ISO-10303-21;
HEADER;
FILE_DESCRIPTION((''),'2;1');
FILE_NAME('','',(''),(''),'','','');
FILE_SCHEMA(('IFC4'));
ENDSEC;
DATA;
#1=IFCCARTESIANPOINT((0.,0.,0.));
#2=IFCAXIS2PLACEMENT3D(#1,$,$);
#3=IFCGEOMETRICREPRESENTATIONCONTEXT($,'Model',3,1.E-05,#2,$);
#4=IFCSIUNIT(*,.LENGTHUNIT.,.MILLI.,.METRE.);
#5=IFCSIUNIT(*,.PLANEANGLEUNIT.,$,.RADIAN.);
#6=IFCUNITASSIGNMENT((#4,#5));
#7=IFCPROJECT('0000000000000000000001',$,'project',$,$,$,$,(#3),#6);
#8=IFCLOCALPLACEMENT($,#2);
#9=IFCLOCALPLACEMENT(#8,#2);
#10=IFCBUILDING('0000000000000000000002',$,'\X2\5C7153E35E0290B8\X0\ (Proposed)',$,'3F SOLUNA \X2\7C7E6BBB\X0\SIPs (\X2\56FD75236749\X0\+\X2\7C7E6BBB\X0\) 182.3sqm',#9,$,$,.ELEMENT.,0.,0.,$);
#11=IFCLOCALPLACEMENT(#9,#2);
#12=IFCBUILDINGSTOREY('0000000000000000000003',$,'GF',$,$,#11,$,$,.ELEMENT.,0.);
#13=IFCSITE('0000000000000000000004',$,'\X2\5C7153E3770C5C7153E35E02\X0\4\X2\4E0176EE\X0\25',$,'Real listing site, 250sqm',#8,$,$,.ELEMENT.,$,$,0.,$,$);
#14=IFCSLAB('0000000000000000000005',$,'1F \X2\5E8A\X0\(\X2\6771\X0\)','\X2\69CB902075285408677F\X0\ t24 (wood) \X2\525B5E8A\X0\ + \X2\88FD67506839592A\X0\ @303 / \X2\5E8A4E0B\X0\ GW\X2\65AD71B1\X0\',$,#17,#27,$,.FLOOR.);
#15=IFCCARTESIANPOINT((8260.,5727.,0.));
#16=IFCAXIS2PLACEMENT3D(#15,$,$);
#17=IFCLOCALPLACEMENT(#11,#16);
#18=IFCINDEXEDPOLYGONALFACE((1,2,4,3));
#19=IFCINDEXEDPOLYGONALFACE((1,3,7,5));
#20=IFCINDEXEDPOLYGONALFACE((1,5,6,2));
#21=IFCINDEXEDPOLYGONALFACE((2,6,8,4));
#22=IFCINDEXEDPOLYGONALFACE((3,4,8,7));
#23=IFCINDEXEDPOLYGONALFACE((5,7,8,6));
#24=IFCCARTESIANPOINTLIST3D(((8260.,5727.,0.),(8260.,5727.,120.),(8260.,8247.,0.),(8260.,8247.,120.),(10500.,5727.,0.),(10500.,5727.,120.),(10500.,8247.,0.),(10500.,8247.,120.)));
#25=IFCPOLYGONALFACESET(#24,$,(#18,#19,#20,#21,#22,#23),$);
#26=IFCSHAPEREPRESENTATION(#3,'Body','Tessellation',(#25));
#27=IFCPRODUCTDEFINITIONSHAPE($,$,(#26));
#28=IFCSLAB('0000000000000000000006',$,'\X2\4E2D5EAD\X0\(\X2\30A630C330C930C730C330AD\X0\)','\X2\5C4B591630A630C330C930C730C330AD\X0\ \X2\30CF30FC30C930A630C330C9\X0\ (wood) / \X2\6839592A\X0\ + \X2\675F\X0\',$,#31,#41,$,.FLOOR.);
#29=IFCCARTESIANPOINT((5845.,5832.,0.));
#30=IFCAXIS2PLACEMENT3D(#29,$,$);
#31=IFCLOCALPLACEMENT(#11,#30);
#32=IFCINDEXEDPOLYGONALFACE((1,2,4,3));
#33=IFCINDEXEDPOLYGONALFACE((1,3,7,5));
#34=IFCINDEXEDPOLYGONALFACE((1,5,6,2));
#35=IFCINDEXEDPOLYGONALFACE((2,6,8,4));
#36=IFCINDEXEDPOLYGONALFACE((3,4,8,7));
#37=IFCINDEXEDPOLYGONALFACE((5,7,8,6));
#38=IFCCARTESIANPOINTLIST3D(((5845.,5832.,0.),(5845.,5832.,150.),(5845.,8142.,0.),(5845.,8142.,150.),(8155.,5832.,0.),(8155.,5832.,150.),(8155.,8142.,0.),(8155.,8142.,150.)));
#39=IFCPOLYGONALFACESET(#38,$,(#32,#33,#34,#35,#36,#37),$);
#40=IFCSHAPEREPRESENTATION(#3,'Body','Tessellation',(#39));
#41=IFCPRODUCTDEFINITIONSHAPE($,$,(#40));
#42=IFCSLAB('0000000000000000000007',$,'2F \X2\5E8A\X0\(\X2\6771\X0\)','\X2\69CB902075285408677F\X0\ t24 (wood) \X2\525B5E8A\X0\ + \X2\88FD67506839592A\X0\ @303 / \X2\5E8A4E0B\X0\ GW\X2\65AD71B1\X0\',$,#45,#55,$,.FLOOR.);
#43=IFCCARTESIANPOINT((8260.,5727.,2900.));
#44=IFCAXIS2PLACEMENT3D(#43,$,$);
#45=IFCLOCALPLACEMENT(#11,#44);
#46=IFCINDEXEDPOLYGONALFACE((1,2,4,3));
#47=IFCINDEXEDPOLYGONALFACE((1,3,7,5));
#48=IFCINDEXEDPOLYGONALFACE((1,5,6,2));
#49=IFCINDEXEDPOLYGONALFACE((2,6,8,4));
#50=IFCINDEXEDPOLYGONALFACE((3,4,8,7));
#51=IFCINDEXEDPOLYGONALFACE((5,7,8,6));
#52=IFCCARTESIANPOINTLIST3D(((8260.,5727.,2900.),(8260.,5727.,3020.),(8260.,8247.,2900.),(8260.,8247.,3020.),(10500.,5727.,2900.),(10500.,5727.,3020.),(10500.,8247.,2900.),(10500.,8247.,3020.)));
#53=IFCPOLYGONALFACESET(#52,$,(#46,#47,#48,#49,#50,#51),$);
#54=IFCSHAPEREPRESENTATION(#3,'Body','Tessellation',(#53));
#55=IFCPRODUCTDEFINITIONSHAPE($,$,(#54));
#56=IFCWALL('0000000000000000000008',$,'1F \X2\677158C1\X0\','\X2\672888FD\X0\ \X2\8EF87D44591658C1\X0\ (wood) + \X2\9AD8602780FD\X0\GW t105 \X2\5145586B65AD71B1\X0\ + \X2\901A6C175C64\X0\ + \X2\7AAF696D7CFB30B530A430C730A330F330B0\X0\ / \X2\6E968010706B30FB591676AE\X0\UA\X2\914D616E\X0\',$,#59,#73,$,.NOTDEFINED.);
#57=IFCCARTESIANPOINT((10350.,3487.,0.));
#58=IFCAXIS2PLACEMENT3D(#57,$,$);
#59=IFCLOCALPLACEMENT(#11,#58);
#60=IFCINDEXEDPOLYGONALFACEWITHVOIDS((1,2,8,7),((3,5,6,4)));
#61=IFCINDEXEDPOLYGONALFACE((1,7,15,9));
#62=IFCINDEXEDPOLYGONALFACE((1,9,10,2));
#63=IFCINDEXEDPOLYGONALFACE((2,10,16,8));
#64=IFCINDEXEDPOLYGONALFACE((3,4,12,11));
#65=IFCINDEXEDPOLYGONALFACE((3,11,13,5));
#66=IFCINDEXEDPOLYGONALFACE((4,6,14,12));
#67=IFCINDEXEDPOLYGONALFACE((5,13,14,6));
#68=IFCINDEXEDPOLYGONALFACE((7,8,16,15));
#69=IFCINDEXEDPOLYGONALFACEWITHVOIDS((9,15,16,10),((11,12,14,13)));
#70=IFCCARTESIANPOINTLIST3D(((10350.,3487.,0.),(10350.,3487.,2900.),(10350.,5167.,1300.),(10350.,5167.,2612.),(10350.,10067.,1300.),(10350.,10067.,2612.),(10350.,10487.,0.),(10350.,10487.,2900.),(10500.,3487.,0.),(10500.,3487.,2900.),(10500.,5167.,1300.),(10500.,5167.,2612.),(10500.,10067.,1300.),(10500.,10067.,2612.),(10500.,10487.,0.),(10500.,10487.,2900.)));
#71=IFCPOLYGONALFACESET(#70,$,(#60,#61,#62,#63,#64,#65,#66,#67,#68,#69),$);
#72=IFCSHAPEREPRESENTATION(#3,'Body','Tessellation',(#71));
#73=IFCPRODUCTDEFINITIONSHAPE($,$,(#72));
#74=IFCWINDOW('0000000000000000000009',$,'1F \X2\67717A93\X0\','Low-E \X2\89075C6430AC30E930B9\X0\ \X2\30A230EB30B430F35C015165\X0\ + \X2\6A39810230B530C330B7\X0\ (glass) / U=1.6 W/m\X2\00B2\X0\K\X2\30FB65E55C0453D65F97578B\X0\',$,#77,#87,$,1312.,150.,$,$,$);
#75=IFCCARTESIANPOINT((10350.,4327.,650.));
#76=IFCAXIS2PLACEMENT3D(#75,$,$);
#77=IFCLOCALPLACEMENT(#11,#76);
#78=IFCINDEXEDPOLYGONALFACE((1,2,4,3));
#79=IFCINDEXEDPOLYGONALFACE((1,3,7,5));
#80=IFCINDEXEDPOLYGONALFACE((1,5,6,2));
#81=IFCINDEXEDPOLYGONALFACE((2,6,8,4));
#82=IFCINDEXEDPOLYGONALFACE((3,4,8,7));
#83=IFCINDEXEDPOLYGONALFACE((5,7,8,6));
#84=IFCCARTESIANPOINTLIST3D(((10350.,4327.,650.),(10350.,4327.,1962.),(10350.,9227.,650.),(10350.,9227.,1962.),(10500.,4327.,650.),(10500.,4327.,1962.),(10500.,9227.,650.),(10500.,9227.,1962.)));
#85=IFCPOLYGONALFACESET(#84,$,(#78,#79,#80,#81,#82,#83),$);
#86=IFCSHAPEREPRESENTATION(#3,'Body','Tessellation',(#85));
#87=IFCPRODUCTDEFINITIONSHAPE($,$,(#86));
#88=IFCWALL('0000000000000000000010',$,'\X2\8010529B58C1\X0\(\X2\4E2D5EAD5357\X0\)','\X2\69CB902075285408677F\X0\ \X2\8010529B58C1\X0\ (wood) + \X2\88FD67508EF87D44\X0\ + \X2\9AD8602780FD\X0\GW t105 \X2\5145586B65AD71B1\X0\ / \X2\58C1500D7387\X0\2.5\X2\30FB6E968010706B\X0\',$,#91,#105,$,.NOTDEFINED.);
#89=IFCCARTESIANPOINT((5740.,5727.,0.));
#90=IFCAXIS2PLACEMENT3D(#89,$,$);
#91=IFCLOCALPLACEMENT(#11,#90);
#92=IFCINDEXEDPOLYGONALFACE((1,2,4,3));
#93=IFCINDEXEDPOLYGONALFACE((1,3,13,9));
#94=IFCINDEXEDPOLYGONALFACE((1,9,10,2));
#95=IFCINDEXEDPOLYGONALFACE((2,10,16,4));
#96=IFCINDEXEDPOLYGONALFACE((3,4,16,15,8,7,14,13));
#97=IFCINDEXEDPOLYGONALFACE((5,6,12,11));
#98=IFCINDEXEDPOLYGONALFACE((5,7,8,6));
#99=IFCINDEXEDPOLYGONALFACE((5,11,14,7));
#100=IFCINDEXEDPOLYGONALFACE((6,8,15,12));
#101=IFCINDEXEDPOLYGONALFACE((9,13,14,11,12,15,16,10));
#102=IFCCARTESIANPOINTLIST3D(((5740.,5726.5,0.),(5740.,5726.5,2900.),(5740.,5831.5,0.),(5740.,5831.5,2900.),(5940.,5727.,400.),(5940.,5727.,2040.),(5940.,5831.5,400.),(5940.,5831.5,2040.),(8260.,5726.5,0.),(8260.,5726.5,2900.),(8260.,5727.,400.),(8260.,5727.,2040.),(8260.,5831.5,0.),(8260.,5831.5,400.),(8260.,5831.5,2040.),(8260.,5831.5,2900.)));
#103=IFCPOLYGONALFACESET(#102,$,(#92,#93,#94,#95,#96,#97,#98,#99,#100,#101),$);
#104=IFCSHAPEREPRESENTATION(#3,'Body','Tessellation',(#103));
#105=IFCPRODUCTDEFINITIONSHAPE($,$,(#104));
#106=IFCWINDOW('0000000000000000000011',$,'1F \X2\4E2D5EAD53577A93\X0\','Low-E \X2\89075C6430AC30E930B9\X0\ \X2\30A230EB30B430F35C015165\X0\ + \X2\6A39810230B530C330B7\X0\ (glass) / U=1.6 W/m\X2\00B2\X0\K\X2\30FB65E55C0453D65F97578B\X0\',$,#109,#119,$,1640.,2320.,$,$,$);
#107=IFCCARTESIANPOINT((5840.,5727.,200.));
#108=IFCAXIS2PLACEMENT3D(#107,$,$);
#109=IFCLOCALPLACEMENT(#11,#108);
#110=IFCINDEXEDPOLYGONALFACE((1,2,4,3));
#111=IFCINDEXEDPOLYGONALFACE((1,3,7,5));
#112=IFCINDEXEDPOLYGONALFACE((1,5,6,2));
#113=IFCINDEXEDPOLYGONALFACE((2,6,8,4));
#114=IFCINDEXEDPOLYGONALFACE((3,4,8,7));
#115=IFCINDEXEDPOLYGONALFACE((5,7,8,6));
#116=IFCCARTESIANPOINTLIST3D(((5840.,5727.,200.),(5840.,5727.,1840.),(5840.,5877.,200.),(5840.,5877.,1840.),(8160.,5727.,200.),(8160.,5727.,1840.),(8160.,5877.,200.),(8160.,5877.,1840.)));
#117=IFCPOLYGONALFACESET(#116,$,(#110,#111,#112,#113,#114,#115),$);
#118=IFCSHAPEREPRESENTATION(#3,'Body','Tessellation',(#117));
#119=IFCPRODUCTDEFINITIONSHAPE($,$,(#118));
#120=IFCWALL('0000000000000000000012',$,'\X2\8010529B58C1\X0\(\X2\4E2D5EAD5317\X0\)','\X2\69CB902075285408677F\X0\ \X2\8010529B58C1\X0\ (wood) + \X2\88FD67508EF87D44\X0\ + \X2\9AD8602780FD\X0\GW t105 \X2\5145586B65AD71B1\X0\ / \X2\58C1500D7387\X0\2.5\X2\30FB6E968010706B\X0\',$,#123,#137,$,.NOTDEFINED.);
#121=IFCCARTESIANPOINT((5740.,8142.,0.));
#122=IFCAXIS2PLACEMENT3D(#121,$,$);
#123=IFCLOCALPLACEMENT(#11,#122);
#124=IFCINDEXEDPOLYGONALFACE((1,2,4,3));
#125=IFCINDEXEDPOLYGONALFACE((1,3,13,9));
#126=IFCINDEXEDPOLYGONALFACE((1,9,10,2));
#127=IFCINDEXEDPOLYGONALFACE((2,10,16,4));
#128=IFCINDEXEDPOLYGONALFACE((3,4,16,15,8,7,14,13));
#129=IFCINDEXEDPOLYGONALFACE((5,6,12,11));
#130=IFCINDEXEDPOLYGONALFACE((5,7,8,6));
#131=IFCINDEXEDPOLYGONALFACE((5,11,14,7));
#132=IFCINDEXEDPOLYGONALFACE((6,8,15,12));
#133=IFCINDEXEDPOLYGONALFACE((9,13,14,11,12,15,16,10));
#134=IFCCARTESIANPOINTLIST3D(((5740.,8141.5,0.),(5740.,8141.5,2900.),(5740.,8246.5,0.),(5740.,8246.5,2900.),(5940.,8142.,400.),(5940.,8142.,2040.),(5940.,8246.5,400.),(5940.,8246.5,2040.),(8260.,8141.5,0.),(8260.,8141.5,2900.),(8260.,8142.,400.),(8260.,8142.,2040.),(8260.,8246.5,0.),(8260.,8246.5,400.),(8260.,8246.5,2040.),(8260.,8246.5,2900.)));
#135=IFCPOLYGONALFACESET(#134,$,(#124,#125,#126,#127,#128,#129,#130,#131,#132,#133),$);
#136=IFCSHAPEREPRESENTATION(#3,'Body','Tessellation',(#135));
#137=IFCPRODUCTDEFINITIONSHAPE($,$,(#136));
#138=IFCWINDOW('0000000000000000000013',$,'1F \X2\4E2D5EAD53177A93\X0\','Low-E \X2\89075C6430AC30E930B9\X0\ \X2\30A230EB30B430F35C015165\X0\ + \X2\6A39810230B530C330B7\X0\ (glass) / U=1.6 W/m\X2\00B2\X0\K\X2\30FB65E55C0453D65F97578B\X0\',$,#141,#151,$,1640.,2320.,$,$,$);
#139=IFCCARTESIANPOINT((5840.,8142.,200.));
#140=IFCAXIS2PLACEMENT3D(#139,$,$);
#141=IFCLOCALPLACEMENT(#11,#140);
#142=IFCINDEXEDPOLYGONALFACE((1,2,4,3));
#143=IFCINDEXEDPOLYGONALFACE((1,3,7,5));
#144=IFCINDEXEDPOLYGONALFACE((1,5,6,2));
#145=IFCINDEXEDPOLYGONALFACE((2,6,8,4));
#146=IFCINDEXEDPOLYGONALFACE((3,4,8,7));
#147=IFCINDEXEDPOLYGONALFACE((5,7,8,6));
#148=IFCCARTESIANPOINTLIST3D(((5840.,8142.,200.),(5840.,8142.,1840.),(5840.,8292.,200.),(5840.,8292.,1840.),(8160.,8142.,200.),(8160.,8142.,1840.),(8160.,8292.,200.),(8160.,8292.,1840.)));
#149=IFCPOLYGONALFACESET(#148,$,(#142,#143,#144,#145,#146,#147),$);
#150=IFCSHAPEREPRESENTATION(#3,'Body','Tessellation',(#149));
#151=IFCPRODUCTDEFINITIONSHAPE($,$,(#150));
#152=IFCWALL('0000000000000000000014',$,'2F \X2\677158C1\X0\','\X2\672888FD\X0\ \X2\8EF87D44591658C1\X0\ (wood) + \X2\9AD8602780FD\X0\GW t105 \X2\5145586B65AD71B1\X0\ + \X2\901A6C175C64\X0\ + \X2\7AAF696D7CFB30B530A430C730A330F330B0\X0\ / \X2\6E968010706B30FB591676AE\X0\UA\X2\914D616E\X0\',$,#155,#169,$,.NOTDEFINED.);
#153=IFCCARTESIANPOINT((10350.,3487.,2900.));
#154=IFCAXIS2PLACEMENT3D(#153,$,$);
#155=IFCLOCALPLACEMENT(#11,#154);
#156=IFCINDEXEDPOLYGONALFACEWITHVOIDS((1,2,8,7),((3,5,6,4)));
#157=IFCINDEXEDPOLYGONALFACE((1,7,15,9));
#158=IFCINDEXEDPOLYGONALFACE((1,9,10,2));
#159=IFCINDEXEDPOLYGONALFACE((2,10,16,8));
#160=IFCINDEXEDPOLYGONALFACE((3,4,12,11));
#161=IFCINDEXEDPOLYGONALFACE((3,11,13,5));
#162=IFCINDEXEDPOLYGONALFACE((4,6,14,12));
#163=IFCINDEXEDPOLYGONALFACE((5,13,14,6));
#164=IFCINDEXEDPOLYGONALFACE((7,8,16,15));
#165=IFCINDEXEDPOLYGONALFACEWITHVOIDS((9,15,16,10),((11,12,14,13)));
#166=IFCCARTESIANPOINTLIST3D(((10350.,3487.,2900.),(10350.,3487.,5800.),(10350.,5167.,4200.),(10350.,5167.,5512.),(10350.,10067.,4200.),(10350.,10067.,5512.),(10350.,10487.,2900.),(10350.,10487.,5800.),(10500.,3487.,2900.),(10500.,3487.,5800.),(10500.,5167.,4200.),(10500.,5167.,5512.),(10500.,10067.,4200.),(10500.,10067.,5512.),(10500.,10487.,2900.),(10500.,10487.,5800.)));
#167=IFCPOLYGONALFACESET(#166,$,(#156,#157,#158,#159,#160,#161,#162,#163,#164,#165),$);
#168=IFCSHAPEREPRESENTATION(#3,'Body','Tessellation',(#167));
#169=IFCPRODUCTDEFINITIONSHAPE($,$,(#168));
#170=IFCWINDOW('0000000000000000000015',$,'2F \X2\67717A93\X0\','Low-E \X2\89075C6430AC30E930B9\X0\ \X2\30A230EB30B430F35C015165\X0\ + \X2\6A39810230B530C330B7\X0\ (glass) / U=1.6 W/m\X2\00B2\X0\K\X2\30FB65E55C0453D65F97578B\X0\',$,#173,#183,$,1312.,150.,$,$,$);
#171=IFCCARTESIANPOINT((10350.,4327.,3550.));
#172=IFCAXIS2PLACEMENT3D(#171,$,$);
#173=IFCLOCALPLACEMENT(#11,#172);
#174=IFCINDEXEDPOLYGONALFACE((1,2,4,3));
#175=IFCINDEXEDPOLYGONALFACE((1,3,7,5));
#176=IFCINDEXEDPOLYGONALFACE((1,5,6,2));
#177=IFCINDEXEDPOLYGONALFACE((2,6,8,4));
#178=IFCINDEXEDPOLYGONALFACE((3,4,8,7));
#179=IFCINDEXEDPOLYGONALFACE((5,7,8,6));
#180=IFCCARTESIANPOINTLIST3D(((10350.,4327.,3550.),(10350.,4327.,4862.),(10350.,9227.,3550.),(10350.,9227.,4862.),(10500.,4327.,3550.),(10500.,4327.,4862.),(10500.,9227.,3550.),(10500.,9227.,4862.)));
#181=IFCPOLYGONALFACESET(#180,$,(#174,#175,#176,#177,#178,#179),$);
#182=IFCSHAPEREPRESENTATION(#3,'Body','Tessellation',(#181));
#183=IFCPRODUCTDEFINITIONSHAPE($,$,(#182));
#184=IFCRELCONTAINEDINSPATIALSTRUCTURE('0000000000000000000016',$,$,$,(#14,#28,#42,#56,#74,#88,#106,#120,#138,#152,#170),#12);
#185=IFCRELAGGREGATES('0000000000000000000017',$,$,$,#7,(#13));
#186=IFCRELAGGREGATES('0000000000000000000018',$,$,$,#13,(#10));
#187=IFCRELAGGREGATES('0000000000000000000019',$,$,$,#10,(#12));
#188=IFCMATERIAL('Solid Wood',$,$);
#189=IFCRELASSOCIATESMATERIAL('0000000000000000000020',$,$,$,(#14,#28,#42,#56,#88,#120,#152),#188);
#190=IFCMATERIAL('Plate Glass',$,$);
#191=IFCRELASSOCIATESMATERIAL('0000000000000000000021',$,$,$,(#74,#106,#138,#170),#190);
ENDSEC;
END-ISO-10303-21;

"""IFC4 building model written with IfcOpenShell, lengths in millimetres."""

from ifc_helpers import new_model, si_unit, frame, frame_2d, origin, place, context, project, spatial, rectangle, extrude, material, element, fill, save


model = new_model("IFC4")

# Units and contexts
model_context = context("Model", 3, precision=1e-05, world=origin())
ifc_project = project(units=[si_unit("LENGTHUNIT", "METRE", prefix="MILLI"), si_unit("PLANEANGLEUNIT", "RADIAN")], contexts=[model_context])

# Site, building, storey
site_placement = place(None, origin())
site = spatial("IfcSite", under=ifc_project, at=site_placement, Name="山口県山口市4丁目25", ObjectType="Real listing site, 250sqm", CompositionType="ELEMENT", RefElevation=0.0)
building_placement = place(site_placement, origin())
building = spatial("IfcBuilding", under=site, at=building_placement, Name="山口市邸 (Proposed)", ObjectType="3F SOLUNA 籾殻SIPs (国産杉+籾殻) 182.3sqm", CompositionType="ELEMENT", ElevationOfRefHeight=0.0, ElevationOfTerrain=0.0)
storey_placement = place(building_placement, origin())
storey = spatial("IfcBuildingStorey", under=building, at=storey_placement, Name="GF", CompositionType="ELEMENT", Elevation=0.0)

# Slabs
ifc_material_1 = material(Name="Solid Wood")
slab_1_placement = place(storey_placement, frame((8260.0, 5727.0, 0.0)))
element("IfcSlab", 1, at=slab_1_placement, inside=storey, material=ifc_material_1, Name="1F 床(東)", Description="構造用合板 t24 (wood) 剛床 + 製材根太 @303 / 床下 GW断熱", PredefinedType="FLOOR", context=model_context, shape_type="SweptSolid", body=[
    extrude(rectangle(XDim=2240.0, YDim=2520.0, at=frame_2d((1120.0, 1260.0))), frame((8260.0, 5727.0, 0.0)), (0.0, 0.0, 1.0), 120.0),
])
slab_2_placement = place(storey_placement, frame((5845.0, 5832.0, 0.0)))
element("IfcSlab", 2, at=slab_2_placement, inside=storey, material=ifc_material_1, Name="中庭(ウッドデッキ)", Description="屋外ウッドデッキ ハードウッド (wood) / 根太 + 束", PredefinedType="FLOOR", context=model_context, shape_type="SweptSolid", body=[
    extrude(rectangle(XDim=2310.0, YDim=2310.0, at=frame_2d((1155.0, 1155.0))), frame((5845.0, 5832.0, 0.0)), (0.0, 0.0, 1.0), 150.0),
])
slab_3_placement = place(storey_placement, frame((8260.0, 5727.0, 2900.0)))
element("IfcSlab", 3, at=slab_3_placement, inside=storey, material=ifc_material_1, Name="2F 床(東)", Description="構造用合板 t24 (wood) 剛床 + 製材根太 @303 / 床下 GW断熱", PredefinedType="FLOOR", context=model_context, shape_type="SweptSolid", body=[
    extrude(rectangle(XDim=2240.0, YDim=2520.0, at=frame_2d((1120.0, 1260.0))), frame((8260.0, 5727.0, 2900.0)), (0.0, 0.0, 1.0), 120.0),
])

# Walls, openings, windows
wall_1_placement = place(storey_placement, frame((10350.0, 3487.0, 0.0)))
wall_1 = element("IfcWall", 4, at=wall_1_placement, inside=storey, material=ifc_material_1, Name="1F 東壁", Description="木製 軸組外壁 (wood) + 高性能GW t105 充填断熱 + 通気層 + 窯業系サイディング / 準耐火・外皮UA配慮", PredefinedType="NOTDEFINED", context=model_context, shape_type="SweptSolid", body=[
    extrude(rectangle(XDim=150.0, YDim=7000.0, at=frame_2d((75.0, 3500.0))), frame((10350.0, 3487.0, 0.0)), (0.0, 0.0, 1.0), 2900.0),
])
opening_1_placement = place(storey_placement, frame((10350.0, 4327.0, 650.0)))
opening_1 = element("IfcOpeningElement", 5, at=opening_1_placement, cuts=wall_1, PredefinedType="NOTDEFINED", context=model_context, shape_type="SweptSolid", body=[
    extrude(rectangle(XDim=150.0, YDim=4900.0, at=frame_2d((75.0, 2450.0))), frame((10350.0, 4327.0, 650.0)), (0.0, 0.0, 1.0), 1312.0),
])
ifc_material_2 = material(Name="Plate Glass")
window_1_placement = place(storey_placement, frame((10350.0, 4327.0, 650.0)))
window_1 = element("IfcWindow", 6, at=window_1_placement, inside=storey, material=ifc_material_2, Name="1F 東窓", Description="Low-E 複層ガラス アルゴン封入 + 樹脂サッシ (glass) / U=1.6 W/m²K・日射取得型", OverallHeight=1312.0, OverallWidth=150.0, context=model_context, shape_type="SweptSolid", body=[
    extrude(rectangle(XDim=150.0, YDim=4900.0, at=frame_2d((75.0, 2450.0))), frame((10350.0, 4327.0, 650.0)), (0.0, 0.0, 1.0), 1312.0),
])
fill(opening_1, window_1)
wall_2_placement = place(storey_placement, frame((5740.0, 5727.0, 0.0)))
wall_2 = element("IfcWall", 7, at=wall_2_placement, inside=storey, material=ifc_material_1, Name="耐力壁(中庭南)", Description="構造用合板 耐力壁 (wood) + 製材軸組 + 高性能GW t105 充填断熱 / 壁倍率2.5・準耐火", PredefinedType="NOTDEFINED", context=model_context, shape_type="SweptSolid", body=[
    extrude(rectangle(XDim=2520.0, YDim=105.0, at=frame_2d((1260.0, 52.0))), frame((5740.0, 5727.0, 0.0)), (0.0, 0.0, 1.0), 2900.0),
])
opening_2_placement = place(storey_placement, frame((5840.0, 5727.0, 200.0)))
opening_2 = element("IfcOpeningElement", 8, at=opening_2_placement, cuts=wall_2, PredefinedType="NOTDEFINED", context=model_context, shape_type="SweptSolid", body=[
    extrude(rectangle(XDim=2320.0, YDim=150.0, at=frame_2d((1160.0, 75.0))), frame((5840.0, 5727.0, 200.0)), (0.0, 0.0, 1.0), 1640.0),
])
window_2_placement = place(storey_placement, frame((5840.0, 5727.0, 200.0)))
window_2 = element("IfcWindow", 9, at=window_2_placement, inside=storey, material=ifc_material_2, Name="1F 中庭南窓", Description="Low-E 複層ガラス アルゴン封入 + 樹脂サッシ (glass) / U=1.6 W/m²K・日射取得型", OverallHeight=1640.0, OverallWidth=2320.0, context=model_context, shape_type="SweptSolid", body=[
    extrude(rectangle(XDim=2320.0, YDim=150.0, at=frame_2d((1160.0, 75.0))), frame((5840.0, 5727.0, 200.0)), (0.0, 0.0, 1.0), 1640.0),
])
fill(opening_2, window_2)
wall_3_placement = place(storey_placement, frame((5740.0, 8142.0, 0.0)))
wall_3 = element("IfcWall", 10, at=wall_3_placement, inside=storey, material=ifc_material_1, Name="耐力壁(中庭北)", Description="構造用合板 耐力壁 (wood) + 製材軸組 + 高性能GW t105 充填断熱 / 壁倍率2.5・準耐火", PredefinedType="NOTDEFINED", context=model_context, shape_type="SweptSolid", body=[
    extrude(rectangle(XDim=2520.0, YDim=105.0, at=frame_2d((1260.0, 52.0))), frame((5740.0, 8142.0, 0.0)), (0.0, 0.0, 1.0), 2900.0),
])
opening_3_placement = place(storey_placement, frame((5840.0, 8142.0, 200.0)))
opening_3 = element("IfcOpeningElement", 11, at=opening_3_placement, cuts=wall_3, PredefinedType="NOTDEFINED", context=model_context, shape_type="SweptSolid", body=[
    extrude(rectangle(XDim=2320.0, YDim=150.0, at=frame_2d((1160.0, 75.0))), frame((5840.0, 8142.0, 200.0)), (0.0, 0.0, 1.0), 1640.0),
])
window_3_placement = place(storey_placement, frame((5840.0, 8142.0, 200.0)))
window_3 = element("IfcWindow", 12, at=window_3_placement, inside=storey, material=ifc_material_2, Name="1F 中庭北窓", Description="Low-E 複層ガラス アルゴン封入 + 樹脂サッシ (glass) / U=1.6 W/m²K・日射取得型", OverallHeight=1640.0, OverallWidth=2320.0, context=model_context, shape_type="SweptSolid", body=[
    extrude(rectangle(XDim=2320.0, YDim=150.0, at=frame_2d((1160.0, 75.0))), frame((5840.0, 8142.0, 200.0)), (0.0, 0.0, 1.0), 1640.0),
])
fill(opening_3, window_3)

# Wall, opening, window
wall_4_placement = place(storey_placement, frame((10350.0, 3487.0, 2900.0)))
wall_4 = element("IfcWall", 13, at=wall_4_placement, inside=storey, material=ifc_material_1, Name="2F 東壁", Description="木製 軸組外壁 (wood) + 高性能GW t105 充填断熱 + 通気層 + 窯業系サイディング / 準耐火・外皮UA配慮", PredefinedType="NOTDEFINED", context=model_context, shape_type="SweptSolid", body=[
    extrude(rectangle(XDim=150.0, YDim=7000.0, at=frame_2d((75.0, 3500.0))), frame((10350.0, 3487.0, 2900.0)), (0.0, 0.0, 1.0), 2900.0),
])
opening_4_placement = place(storey_placement, frame((10350.0, 4327.0, 3550.0)))
opening_4 = element("IfcOpeningElement", 14, at=opening_4_placement, cuts=wall_4, PredefinedType="NOTDEFINED", context=model_context, shape_type="SweptSolid", body=[
    extrude(rectangle(XDim=150.0, YDim=4900.0, at=frame_2d((75.0, 2450.0))), frame((10350.0, 4327.0, 3550.0)), (0.0, 0.0, 1.0), 1312.0),
])
window_4_placement = place(storey_placement, frame((10350.0, 4327.0, 3550.0)))
window_4 = element("IfcWindow", 15, at=window_4_placement, inside=storey, material=ifc_material_2, Name="2F 東窓", Description="Low-E 複層ガラス アルゴン封入 + 樹脂サッシ (glass) / U=1.6 W/m²K・日射取得型", OverallHeight=1312.0, OverallWidth=150.0, context=model_context, shape_type="SweptSolid", body=[
    extrude(rectangle(XDim=150.0, YDim=4900.0, at=frame_2d((75.0, 2450.0))), frame((10350.0, 4327.0, 3550.0)), (0.0, 0.0, 1.0), 1312.0),
])
fill(opening_4, window_4)

save(model, "model.ifc")
